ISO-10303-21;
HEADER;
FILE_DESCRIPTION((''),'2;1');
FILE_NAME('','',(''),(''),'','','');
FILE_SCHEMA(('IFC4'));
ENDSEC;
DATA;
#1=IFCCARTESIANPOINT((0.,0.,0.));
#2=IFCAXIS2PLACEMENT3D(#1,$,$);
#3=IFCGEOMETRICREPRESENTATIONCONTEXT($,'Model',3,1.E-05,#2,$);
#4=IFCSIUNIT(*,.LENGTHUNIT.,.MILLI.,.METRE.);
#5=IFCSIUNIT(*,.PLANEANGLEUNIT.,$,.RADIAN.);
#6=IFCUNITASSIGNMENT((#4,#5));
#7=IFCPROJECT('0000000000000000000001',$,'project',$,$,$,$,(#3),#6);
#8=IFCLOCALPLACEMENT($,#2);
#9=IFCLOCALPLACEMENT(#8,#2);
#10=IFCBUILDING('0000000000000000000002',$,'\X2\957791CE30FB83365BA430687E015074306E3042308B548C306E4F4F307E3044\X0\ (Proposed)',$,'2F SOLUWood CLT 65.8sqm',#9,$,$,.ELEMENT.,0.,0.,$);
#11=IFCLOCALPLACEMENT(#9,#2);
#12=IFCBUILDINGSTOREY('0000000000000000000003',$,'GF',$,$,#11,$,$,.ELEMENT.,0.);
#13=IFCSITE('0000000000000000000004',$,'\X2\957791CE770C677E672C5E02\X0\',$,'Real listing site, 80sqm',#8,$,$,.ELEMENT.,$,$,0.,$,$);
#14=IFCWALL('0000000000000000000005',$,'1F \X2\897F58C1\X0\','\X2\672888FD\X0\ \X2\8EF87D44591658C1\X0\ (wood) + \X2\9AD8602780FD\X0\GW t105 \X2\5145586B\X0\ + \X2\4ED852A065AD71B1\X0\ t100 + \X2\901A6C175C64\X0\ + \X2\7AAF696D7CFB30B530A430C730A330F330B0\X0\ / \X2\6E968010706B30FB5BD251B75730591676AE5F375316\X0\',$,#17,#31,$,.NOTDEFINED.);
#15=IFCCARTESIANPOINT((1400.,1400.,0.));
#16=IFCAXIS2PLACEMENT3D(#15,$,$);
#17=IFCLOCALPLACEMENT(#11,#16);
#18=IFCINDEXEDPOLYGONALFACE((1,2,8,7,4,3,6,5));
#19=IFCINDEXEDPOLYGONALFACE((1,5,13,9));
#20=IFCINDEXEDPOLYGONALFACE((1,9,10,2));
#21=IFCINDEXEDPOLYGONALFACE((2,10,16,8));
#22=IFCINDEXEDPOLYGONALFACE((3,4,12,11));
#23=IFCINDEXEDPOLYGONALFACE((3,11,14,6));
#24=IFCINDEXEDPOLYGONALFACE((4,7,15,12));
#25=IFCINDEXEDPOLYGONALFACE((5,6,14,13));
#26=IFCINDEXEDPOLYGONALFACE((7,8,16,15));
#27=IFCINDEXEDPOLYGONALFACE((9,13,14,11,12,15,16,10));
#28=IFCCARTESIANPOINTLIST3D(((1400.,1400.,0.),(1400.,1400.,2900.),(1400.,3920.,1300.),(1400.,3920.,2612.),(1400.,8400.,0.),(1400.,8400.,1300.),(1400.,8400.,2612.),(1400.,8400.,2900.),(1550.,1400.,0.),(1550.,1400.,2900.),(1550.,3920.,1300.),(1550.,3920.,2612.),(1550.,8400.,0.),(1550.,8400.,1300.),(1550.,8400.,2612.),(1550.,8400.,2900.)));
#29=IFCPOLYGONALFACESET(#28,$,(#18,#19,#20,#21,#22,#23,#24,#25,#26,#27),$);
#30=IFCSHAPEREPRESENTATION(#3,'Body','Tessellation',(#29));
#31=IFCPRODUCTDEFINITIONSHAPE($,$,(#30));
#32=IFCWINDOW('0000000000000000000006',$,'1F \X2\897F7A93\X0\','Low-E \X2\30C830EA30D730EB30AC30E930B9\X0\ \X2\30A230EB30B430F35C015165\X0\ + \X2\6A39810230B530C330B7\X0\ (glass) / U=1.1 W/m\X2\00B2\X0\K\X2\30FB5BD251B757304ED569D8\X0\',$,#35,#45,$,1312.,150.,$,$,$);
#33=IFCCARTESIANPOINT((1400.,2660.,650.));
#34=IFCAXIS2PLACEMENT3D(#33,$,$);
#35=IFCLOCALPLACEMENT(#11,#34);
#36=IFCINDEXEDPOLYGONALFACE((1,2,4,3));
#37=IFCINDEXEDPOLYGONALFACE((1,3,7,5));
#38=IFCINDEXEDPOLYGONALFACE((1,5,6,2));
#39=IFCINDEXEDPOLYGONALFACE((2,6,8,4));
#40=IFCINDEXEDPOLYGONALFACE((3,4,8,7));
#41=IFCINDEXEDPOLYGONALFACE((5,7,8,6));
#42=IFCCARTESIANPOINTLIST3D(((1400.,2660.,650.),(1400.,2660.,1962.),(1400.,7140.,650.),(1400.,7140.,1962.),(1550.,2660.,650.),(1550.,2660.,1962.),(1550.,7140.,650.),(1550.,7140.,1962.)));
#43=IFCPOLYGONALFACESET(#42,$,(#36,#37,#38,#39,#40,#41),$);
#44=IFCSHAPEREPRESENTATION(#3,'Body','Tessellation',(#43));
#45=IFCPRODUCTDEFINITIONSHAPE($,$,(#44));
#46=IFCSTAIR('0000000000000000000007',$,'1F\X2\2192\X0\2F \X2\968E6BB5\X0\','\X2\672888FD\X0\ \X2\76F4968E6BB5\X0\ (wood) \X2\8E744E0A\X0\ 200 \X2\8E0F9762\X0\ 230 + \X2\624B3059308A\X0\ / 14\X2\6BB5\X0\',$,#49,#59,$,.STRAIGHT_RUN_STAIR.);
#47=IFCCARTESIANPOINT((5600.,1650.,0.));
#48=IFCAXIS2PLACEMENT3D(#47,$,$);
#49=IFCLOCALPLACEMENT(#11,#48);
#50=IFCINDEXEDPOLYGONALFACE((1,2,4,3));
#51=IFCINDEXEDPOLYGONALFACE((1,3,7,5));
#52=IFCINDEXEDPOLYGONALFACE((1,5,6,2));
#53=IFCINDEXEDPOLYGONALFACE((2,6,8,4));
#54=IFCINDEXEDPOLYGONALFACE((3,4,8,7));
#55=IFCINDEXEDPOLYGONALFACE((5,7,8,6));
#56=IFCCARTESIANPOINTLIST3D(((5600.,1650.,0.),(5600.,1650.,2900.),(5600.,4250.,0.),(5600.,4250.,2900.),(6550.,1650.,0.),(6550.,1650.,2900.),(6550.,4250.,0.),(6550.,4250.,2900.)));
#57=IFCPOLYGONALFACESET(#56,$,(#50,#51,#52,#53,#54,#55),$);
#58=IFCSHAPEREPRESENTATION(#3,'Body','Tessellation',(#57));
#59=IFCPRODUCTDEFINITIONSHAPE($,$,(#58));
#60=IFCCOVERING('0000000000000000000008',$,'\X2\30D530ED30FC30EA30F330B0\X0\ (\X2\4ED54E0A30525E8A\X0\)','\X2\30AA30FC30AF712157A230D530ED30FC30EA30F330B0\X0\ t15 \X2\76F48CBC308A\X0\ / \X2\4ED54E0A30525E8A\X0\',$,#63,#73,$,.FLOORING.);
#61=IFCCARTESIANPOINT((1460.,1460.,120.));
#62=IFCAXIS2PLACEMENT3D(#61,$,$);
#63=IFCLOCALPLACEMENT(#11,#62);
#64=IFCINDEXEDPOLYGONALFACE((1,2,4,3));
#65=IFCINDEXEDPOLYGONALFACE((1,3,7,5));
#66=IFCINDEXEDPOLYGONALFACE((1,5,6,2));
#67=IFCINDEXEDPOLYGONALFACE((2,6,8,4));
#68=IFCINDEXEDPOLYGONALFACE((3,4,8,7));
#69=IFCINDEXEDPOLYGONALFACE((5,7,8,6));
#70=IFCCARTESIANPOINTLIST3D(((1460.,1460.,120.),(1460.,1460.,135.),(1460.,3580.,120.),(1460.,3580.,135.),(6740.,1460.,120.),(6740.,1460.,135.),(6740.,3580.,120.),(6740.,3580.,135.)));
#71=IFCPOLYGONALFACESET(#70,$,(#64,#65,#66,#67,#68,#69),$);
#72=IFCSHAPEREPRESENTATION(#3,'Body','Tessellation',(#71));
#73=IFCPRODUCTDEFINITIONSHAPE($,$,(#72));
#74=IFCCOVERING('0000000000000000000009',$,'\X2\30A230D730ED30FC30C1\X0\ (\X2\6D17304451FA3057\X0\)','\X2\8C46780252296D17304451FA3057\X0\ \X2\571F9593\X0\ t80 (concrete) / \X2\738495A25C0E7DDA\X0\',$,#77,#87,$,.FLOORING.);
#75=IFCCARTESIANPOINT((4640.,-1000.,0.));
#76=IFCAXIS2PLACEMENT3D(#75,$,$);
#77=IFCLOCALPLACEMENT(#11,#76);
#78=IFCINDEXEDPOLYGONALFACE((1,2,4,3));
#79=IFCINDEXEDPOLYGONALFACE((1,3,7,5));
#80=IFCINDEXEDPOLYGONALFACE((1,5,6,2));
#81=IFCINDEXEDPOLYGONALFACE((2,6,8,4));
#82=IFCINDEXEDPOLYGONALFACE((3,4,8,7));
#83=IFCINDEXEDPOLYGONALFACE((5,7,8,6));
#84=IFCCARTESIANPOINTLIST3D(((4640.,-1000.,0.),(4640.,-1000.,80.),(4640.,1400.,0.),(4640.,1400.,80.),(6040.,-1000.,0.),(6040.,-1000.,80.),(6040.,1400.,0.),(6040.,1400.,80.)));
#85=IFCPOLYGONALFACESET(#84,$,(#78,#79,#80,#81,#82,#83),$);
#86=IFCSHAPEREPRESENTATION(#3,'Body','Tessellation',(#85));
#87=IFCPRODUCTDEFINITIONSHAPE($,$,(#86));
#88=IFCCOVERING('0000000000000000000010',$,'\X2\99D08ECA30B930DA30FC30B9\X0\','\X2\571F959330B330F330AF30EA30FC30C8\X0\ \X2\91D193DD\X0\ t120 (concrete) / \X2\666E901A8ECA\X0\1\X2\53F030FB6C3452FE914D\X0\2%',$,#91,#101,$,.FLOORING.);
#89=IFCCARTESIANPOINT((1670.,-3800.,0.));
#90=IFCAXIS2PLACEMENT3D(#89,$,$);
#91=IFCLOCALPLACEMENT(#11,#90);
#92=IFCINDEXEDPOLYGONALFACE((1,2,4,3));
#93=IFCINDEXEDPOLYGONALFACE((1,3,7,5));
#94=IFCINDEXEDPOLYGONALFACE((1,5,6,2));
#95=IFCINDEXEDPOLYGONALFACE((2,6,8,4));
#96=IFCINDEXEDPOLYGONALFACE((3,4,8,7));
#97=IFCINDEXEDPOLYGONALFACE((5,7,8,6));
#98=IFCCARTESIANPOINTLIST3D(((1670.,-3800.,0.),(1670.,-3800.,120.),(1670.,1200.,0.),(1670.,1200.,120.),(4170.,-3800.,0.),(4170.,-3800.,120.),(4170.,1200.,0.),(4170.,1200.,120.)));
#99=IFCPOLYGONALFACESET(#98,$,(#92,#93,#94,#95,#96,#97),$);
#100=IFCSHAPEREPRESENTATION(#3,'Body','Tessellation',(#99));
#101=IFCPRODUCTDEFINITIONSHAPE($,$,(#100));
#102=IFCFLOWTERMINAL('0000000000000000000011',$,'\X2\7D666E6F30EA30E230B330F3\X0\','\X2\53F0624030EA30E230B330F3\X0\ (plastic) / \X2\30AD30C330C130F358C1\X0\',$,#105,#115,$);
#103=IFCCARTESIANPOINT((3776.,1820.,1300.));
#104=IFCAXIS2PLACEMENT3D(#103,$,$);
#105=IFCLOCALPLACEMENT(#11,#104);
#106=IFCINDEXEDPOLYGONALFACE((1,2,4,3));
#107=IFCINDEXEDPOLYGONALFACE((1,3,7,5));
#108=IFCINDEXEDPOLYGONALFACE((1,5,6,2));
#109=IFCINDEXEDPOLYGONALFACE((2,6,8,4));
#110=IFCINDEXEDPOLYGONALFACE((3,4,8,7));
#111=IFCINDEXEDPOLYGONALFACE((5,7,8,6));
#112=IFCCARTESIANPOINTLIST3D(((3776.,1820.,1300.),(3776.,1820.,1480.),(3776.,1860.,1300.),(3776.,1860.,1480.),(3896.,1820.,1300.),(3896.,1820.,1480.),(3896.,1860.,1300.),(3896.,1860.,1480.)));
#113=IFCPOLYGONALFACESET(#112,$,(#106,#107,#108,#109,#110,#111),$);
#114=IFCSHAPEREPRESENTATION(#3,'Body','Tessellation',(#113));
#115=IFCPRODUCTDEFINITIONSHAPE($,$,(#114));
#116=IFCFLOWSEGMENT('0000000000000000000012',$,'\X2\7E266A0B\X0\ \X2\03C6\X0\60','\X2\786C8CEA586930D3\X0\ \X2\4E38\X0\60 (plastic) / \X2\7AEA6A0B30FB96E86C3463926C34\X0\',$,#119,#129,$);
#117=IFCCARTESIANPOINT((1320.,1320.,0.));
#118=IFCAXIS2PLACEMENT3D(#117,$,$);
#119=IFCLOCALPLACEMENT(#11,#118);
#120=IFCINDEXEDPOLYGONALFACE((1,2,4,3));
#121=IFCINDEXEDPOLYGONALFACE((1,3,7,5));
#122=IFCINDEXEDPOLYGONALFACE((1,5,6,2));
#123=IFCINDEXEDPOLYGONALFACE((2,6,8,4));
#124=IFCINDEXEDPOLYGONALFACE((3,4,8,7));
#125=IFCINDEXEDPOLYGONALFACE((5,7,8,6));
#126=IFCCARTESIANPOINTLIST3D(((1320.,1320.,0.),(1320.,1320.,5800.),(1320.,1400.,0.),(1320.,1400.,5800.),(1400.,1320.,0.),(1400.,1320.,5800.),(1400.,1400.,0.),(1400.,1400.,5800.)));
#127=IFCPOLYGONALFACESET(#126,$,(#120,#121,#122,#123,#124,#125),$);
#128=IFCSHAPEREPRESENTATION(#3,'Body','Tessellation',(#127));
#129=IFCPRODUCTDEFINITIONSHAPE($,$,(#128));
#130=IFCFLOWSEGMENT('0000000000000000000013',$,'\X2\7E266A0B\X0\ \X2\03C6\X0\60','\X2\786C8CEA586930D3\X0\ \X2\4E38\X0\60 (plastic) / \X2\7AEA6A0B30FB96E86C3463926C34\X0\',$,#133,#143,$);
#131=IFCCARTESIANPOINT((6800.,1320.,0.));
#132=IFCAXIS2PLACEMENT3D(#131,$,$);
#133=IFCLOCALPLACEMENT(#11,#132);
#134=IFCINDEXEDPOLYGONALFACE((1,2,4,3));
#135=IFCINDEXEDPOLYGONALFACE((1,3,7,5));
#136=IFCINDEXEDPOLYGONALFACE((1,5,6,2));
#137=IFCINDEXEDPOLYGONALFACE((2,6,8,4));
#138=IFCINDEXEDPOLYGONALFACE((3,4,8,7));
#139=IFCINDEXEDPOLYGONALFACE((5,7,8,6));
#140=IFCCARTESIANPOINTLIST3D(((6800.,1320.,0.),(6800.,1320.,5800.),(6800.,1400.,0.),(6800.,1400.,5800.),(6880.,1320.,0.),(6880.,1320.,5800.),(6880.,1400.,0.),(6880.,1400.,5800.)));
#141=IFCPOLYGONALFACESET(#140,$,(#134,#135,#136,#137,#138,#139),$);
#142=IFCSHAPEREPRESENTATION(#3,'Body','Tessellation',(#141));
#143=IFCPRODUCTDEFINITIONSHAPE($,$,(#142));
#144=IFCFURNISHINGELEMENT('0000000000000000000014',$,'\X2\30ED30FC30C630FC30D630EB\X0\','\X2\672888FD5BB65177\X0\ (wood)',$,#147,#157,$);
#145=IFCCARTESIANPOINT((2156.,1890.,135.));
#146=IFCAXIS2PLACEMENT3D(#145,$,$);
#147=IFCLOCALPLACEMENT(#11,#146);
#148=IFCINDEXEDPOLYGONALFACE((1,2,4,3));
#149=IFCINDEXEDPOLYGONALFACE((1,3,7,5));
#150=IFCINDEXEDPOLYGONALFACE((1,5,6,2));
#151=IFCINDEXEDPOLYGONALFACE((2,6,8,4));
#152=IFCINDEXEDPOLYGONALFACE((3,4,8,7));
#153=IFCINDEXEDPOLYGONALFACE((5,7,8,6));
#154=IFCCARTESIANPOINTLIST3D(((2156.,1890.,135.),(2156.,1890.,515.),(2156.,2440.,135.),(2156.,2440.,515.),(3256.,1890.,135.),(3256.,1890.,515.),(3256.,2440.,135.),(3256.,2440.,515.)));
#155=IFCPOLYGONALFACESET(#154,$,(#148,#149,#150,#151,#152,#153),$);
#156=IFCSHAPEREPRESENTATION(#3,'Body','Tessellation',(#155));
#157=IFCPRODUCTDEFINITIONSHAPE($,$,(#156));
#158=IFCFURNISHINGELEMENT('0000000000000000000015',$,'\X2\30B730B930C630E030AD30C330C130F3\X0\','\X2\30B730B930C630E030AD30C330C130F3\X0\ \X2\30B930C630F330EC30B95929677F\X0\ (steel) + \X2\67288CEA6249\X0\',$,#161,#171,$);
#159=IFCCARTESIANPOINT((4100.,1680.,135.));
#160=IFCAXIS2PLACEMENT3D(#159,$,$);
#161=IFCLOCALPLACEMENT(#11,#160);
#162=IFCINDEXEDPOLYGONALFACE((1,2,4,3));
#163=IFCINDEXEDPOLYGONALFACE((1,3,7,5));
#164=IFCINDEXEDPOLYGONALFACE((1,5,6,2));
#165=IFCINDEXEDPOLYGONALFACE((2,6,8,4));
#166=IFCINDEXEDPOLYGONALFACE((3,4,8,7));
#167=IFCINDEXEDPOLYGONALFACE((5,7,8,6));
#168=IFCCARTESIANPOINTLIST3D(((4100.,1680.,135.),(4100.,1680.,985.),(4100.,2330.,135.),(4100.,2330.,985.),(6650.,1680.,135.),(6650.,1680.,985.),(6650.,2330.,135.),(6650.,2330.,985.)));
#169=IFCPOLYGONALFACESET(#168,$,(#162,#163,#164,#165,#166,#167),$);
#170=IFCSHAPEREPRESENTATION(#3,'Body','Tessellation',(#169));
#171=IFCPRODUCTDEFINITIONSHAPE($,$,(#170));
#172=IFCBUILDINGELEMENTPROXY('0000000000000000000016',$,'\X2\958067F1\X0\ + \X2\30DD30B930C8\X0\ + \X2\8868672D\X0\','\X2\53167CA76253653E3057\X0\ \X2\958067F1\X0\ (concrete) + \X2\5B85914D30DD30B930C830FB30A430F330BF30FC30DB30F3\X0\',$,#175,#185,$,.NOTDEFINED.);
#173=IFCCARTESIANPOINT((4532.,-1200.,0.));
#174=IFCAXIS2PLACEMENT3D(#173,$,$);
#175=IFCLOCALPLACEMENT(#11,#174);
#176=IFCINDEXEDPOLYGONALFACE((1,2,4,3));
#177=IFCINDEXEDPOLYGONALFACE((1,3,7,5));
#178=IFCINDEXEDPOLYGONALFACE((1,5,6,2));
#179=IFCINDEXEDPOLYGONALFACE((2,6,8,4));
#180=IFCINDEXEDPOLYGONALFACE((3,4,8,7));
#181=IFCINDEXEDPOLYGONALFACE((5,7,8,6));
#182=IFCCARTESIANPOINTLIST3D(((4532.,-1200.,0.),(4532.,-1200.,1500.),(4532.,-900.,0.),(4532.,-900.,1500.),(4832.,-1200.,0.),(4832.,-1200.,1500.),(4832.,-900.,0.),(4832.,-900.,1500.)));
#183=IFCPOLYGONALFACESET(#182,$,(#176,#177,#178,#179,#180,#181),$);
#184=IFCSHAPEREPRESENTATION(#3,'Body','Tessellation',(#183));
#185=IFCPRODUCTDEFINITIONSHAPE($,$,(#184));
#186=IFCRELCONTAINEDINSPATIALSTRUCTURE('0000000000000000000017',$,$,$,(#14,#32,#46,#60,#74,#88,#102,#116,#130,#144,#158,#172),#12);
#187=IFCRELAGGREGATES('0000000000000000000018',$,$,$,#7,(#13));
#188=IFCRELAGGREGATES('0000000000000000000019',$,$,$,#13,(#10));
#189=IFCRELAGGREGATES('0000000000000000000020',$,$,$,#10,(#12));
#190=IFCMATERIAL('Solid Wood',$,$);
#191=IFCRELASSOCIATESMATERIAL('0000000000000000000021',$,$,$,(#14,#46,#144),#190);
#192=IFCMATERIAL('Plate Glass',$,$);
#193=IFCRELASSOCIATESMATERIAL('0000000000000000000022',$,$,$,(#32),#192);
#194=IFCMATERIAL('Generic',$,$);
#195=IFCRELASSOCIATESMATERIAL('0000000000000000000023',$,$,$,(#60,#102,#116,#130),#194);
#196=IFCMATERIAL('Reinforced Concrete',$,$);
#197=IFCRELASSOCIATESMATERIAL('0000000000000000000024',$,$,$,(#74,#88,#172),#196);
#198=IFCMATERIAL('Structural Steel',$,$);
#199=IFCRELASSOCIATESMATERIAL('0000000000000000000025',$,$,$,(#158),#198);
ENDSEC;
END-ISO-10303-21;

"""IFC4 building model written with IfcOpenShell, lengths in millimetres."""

from ifc_helpers import new_model, si_unit, frame, frame_2d, origin, place, context, project, spatial, rectangle, extrude, material, element, fill, save


model = new_model("IFC4")

# Units and contexts
model_context = context("Model", 3, precision=1e-05, world=origin())
ifc_project = project(units=[si_unit("LENGTHUNIT", "METRE", prefix="MILLI"), si_unit("PLANEANGLEUNIT", "RADIAN")], contexts=[model_context])

# Site, building, storey
site_placement = place(None, origin())
site = spatial("IfcSite", under=ifc_project, at=site_placement, Name="長野県松本市", ObjectType="Real listing site, 80sqm", CompositionType="ELEMENT", RefElevation=0.0)
building_placement = place(site_placement, origin())
building = spatial("IfcBuilding", under=site, at=building_placement, Name="長野・茶室と縁側のある和の住まい (Proposed)", ObjectType="2F SOLUWood CLT 65.8sqm", CompositionType="ELEMENT", ElevationOfRefHeight=0.0, ElevationOfTerrain=0.0)
storey_placement = place(building_placement, origin())
storey = spatial("IfcBuildingStorey", under=building, at=storey_placement, Name="GF", CompositionType="ELEMENT", Elevation=0.0)

# Shared definitions
ifc_material_1 = material(Name="Solid Wood")

# Shared definitions
ifc_material_2 = material(Name="Reinforced Concrete")

# Shared definitions
ifc_material_3 = material(Name="Plate Glass")

# Wall, opening, window
wall_1_placement = place(storey_placement, frame((1400.0, 1400.0, 0.0)))
wall_1 = element("IfcWall", 1, at=wall_1_placement, inside=storey, material=ifc_material_1, Name="1F 西壁", Description="木製 軸組外壁 (wood) + 高性能GW t105 充填 + 付加断熱 t100 + 通気層 + 窯業系サイディング / 準耐火・寒冷地外皮強化", PredefinedType="NOTDEFINED", context=model_context, shape_type="SweptSolid", body=[
    extrude(rectangle(XDim=150.0, YDim=7000.0, at=frame_2d((75.0, 3500.0))), frame((1400.0, 1400.0, 0.0)), (0.0, 0.0, 1.0), 2900.0),
])
opening_1_placement = place(storey_placement, frame((1400.0, 2660.0, 650.0)))
opening_1 = element("IfcOpeningElement", 2, at=opening_1_placement, cuts=wall_1, PredefinedType="NOTDEFINED", context=model_context, shape_type="SweptSolid", body=[
    extrude(rectangle(XDim=150.0, YDim=4480.0, at=frame_2d((75.0, 2240.0))), frame((1400.0, 2660.0, 650.0)), (0.0, 0.0, 1.0), 1312.0),
])
window_1_placement = place(storey_placement, frame((1400.0, 2660.0, 650.0)))
window_1 = element("IfcWindow", 3, at=window_1_placement, inside=storey, material=ifc_material_3, Name="1F 西窓", Description="Low-E トリプルガラス アルゴン封入 + 樹脂サッシ (glass) / U=1.1 W/m²K・寒冷地仕様", OverallHeight=1312.0, OverallWidth=150.0, context=model_context, shape_type="SweptSolid", body=[
    extrude(rectangle(XDim=150.0, YDim=4480.0, at=frame_2d((75.0, 2240.0))), frame((1400.0, 2660.0, 650.0)), (0.0, 0.0, 1.0), 1312.0),
])
fill(opening_1, window_1)

# Stair
stair_placement = place(storey_placement, frame((5600.0, 1650.0, 0.0)))
element("IfcStair", 4, at=stair_placement, inside=storey, material=ifc_material_1, Name="1F→2F 階段", Description="木製 直階段 (wood) 蹴上 200 踏面 230 + 手すり / 14段", PredefinedType="STRAIGHT_RUN_STAIR", context=model_context, shape_type="SweptSolid", body=[
    extrude(rectangle(XDim=950.0, YDim=2600.0, at=frame_2d((475.0, 1300.0))), frame((5600.0, 1650.0, 0.0)), (0.0, 0.0, 1.0), 2900.0),
])

# Coverings
ifc_material_4 = material(Name="Generic")
covering_1_placement = place(storey_placement, frame((1460.0, 1460.0, 120.0)))
element("IfcCovering", 5, at=covering_1_placement, inside=storey, material=ifc_material_4, Name="フローリング (仕上げ床)", Description="オーク無垢フローリング t15 直貼り / 仕上げ床", PredefinedType="FLOORING", context=model_context, shape_type="SweptSolid", body=[
    extrude(rectangle(XDim=5280.0, YDim=2120.0, at=frame_2d((2640.0, 1060.0))), frame((1460.0, 1460.0, 120.0)), (0.0, 0.0, 1.0), 15.0),
])
covering_2_placement = place(storey_placement, frame((4640.0, -1000.0, 0.0)))
element("IfcCovering", 6, at=covering_2_placement, inside=storey, material=ifc_material_2, Name="アプローチ (洗い出し)", Description="豆砂利洗い出し 土間 t80 (concrete) / 玄関導線", PredefinedType="FLOORING", context=model_context, shape_type="SweptSolid", body=[
    extrude(rectangle(XDim=1400.0, YDim=2400.0, at=frame_2d((700.0, 1200.0))), frame((4640.0, -1000.0, 0.0)), (0.0, 0.0, 1.0), 80.0),
])
covering_3_placement = place(storey_placement, frame((1670.0, -3800.0, 0.0)))
element("IfcCovering", 7, at=covering_3_placement, inside=storey, material=ifc_material_2, Name="駐車スペース", Description="土間コンクリート 金鏝 t120 (concrete) / 普通車1台・水勾配2%", PredefinedType="FLOORING", context=model_context, shape_type="SweptSolid", body=[
    extrude(rectangle(XDim=2500.0, YDim=5000.0, at=frame_2d((1250.0, 2500.0))), frame((1670.0, -3800.0, 0.0)), (0.0, 0.0, 1.0), 120.0),
])

# Flow terminal
flow_terminal_placement = place(storey_placement, frame((3776.0, 1820.0, 1300.0)))
element("IfcFlowTerminal", 8, at=flow_terminal_placement, inside=storey, material=ifc_material_4, Name="給湯リモコン", Description="台所リモコン (plastic) / キッチン壁", context=model_context, shape_type="SweptSolid", body=[
    extrude(rectangle(XDim=120.0, YDim=40.0, at=frame_2d((60.0, 20.0))), frame((3776.0, 1820.0, 1300.0)), (0.0, 0.0, 1.0), 180.0),
])

# Flow segments
flow_segment_1_placement = place(storey_placement, frame((1320.0, 1320.0, 0.0)))
element("IfcFlowSegment", 9, at=flow_segment_1_placement, inside=storey, material=ifc_material_4, Name="縦樋 φ60", Description="硬質塩ビ 丸60 (plastic) / 竪樋・雨水排水", context=model_context, shape_type="SweptSolid", body=[
    extrude(rectangle(XDim=80.0, YDim=80.0, at=frame_2d((40.0, 40.0))), frame((1320.0, 1320.0, 0.0)), (0.0, 0.0, 1.0), 5800.0),
])
flow_segment_2_placement = place(storey_placement, frame((6800.0, 1320.0, 0.0)))
element("IfcFlowSegment", 10, at=flow_segment_2_placement, inside=storey, material=ifc_material_4, Name="縦樋 φ60", Description="硬質塩ビ 丸60 (plastic) / 竪樋・雨水排水", context=model_context, shape_type="SweptSolid", body=[
    extrude(rectangle(XDim=80.0, YDim=80.0, at=frame_2d((40.0, 40.0))), frame((6800.0, 1320.0, 0.0)), (0.0, 0.0, 1.0), 5800.0),
])

# Furnishing elements
furnishing_1_placement = place(storey_placement, frame((2156.0, 1890.0, 135.0)))
element("IfcFurnishingElement", 11, at=furnishing_1_placement, inside=storey, material=ifc_material_1, Name="ローテーブル", Description="木製家具 (wood)", context=model_context, shape_type="SweptSolid", body=[
    extrude(rectangle(XDim=1100.0, YDim=550.0, at=frame_2d((550.0, 275.0))), frame((2156.0, 1890.0, 135.0)), (0.0, 0.0, 1.0), 380.0),
])
ifc_material_5 = material(Name="Structural Steel")
furnishing_2_placement = place(storey_placement, frame((4100.0, 1680.0, 135.0)))
element("IfcFurnishingElement", 12, at=furnishing_2_placement, inside=storey, material=ifc_material_5, Name="システムキッチン", Description="システムキッチン ステンレス天板 (steel) + 木質扉", context=model_context, shape_type="SweptSolid", body=[
    extrude(rectangle(XDim=2550.0, YDim=650.0, at=frame_2d((1275.0, 325.0))), frame((4100.0, 1680.0, 135.0)), (0.0, 0.0, 1.0), 850.0),
])

# Building element proxy
proxy_placement = place(storey_placement, frame((4532.0, -1200.0, 0.0)))
element("IfcBuildingElementProxy", 13, at=proxy_placement, inside=storey, material=ifc_material_2, Name="門柱 + ポスト + 表札", Description="化粧打放し 門柱 (concrete) + 宅配ポスト・インターホン", PredefinedType="NOTDEFINED", context=model_context, shape_type="SweptSolid", body=[
    extrude(rectangle(XDim=300.0, YDim=300.0, at=frame_2d((150.0, 150.0))), frame((4532.0, -1200.0, 0.0)), (0.0, 0.0, 1.0), 1500.0),
])

save(model, "model.ifc")
